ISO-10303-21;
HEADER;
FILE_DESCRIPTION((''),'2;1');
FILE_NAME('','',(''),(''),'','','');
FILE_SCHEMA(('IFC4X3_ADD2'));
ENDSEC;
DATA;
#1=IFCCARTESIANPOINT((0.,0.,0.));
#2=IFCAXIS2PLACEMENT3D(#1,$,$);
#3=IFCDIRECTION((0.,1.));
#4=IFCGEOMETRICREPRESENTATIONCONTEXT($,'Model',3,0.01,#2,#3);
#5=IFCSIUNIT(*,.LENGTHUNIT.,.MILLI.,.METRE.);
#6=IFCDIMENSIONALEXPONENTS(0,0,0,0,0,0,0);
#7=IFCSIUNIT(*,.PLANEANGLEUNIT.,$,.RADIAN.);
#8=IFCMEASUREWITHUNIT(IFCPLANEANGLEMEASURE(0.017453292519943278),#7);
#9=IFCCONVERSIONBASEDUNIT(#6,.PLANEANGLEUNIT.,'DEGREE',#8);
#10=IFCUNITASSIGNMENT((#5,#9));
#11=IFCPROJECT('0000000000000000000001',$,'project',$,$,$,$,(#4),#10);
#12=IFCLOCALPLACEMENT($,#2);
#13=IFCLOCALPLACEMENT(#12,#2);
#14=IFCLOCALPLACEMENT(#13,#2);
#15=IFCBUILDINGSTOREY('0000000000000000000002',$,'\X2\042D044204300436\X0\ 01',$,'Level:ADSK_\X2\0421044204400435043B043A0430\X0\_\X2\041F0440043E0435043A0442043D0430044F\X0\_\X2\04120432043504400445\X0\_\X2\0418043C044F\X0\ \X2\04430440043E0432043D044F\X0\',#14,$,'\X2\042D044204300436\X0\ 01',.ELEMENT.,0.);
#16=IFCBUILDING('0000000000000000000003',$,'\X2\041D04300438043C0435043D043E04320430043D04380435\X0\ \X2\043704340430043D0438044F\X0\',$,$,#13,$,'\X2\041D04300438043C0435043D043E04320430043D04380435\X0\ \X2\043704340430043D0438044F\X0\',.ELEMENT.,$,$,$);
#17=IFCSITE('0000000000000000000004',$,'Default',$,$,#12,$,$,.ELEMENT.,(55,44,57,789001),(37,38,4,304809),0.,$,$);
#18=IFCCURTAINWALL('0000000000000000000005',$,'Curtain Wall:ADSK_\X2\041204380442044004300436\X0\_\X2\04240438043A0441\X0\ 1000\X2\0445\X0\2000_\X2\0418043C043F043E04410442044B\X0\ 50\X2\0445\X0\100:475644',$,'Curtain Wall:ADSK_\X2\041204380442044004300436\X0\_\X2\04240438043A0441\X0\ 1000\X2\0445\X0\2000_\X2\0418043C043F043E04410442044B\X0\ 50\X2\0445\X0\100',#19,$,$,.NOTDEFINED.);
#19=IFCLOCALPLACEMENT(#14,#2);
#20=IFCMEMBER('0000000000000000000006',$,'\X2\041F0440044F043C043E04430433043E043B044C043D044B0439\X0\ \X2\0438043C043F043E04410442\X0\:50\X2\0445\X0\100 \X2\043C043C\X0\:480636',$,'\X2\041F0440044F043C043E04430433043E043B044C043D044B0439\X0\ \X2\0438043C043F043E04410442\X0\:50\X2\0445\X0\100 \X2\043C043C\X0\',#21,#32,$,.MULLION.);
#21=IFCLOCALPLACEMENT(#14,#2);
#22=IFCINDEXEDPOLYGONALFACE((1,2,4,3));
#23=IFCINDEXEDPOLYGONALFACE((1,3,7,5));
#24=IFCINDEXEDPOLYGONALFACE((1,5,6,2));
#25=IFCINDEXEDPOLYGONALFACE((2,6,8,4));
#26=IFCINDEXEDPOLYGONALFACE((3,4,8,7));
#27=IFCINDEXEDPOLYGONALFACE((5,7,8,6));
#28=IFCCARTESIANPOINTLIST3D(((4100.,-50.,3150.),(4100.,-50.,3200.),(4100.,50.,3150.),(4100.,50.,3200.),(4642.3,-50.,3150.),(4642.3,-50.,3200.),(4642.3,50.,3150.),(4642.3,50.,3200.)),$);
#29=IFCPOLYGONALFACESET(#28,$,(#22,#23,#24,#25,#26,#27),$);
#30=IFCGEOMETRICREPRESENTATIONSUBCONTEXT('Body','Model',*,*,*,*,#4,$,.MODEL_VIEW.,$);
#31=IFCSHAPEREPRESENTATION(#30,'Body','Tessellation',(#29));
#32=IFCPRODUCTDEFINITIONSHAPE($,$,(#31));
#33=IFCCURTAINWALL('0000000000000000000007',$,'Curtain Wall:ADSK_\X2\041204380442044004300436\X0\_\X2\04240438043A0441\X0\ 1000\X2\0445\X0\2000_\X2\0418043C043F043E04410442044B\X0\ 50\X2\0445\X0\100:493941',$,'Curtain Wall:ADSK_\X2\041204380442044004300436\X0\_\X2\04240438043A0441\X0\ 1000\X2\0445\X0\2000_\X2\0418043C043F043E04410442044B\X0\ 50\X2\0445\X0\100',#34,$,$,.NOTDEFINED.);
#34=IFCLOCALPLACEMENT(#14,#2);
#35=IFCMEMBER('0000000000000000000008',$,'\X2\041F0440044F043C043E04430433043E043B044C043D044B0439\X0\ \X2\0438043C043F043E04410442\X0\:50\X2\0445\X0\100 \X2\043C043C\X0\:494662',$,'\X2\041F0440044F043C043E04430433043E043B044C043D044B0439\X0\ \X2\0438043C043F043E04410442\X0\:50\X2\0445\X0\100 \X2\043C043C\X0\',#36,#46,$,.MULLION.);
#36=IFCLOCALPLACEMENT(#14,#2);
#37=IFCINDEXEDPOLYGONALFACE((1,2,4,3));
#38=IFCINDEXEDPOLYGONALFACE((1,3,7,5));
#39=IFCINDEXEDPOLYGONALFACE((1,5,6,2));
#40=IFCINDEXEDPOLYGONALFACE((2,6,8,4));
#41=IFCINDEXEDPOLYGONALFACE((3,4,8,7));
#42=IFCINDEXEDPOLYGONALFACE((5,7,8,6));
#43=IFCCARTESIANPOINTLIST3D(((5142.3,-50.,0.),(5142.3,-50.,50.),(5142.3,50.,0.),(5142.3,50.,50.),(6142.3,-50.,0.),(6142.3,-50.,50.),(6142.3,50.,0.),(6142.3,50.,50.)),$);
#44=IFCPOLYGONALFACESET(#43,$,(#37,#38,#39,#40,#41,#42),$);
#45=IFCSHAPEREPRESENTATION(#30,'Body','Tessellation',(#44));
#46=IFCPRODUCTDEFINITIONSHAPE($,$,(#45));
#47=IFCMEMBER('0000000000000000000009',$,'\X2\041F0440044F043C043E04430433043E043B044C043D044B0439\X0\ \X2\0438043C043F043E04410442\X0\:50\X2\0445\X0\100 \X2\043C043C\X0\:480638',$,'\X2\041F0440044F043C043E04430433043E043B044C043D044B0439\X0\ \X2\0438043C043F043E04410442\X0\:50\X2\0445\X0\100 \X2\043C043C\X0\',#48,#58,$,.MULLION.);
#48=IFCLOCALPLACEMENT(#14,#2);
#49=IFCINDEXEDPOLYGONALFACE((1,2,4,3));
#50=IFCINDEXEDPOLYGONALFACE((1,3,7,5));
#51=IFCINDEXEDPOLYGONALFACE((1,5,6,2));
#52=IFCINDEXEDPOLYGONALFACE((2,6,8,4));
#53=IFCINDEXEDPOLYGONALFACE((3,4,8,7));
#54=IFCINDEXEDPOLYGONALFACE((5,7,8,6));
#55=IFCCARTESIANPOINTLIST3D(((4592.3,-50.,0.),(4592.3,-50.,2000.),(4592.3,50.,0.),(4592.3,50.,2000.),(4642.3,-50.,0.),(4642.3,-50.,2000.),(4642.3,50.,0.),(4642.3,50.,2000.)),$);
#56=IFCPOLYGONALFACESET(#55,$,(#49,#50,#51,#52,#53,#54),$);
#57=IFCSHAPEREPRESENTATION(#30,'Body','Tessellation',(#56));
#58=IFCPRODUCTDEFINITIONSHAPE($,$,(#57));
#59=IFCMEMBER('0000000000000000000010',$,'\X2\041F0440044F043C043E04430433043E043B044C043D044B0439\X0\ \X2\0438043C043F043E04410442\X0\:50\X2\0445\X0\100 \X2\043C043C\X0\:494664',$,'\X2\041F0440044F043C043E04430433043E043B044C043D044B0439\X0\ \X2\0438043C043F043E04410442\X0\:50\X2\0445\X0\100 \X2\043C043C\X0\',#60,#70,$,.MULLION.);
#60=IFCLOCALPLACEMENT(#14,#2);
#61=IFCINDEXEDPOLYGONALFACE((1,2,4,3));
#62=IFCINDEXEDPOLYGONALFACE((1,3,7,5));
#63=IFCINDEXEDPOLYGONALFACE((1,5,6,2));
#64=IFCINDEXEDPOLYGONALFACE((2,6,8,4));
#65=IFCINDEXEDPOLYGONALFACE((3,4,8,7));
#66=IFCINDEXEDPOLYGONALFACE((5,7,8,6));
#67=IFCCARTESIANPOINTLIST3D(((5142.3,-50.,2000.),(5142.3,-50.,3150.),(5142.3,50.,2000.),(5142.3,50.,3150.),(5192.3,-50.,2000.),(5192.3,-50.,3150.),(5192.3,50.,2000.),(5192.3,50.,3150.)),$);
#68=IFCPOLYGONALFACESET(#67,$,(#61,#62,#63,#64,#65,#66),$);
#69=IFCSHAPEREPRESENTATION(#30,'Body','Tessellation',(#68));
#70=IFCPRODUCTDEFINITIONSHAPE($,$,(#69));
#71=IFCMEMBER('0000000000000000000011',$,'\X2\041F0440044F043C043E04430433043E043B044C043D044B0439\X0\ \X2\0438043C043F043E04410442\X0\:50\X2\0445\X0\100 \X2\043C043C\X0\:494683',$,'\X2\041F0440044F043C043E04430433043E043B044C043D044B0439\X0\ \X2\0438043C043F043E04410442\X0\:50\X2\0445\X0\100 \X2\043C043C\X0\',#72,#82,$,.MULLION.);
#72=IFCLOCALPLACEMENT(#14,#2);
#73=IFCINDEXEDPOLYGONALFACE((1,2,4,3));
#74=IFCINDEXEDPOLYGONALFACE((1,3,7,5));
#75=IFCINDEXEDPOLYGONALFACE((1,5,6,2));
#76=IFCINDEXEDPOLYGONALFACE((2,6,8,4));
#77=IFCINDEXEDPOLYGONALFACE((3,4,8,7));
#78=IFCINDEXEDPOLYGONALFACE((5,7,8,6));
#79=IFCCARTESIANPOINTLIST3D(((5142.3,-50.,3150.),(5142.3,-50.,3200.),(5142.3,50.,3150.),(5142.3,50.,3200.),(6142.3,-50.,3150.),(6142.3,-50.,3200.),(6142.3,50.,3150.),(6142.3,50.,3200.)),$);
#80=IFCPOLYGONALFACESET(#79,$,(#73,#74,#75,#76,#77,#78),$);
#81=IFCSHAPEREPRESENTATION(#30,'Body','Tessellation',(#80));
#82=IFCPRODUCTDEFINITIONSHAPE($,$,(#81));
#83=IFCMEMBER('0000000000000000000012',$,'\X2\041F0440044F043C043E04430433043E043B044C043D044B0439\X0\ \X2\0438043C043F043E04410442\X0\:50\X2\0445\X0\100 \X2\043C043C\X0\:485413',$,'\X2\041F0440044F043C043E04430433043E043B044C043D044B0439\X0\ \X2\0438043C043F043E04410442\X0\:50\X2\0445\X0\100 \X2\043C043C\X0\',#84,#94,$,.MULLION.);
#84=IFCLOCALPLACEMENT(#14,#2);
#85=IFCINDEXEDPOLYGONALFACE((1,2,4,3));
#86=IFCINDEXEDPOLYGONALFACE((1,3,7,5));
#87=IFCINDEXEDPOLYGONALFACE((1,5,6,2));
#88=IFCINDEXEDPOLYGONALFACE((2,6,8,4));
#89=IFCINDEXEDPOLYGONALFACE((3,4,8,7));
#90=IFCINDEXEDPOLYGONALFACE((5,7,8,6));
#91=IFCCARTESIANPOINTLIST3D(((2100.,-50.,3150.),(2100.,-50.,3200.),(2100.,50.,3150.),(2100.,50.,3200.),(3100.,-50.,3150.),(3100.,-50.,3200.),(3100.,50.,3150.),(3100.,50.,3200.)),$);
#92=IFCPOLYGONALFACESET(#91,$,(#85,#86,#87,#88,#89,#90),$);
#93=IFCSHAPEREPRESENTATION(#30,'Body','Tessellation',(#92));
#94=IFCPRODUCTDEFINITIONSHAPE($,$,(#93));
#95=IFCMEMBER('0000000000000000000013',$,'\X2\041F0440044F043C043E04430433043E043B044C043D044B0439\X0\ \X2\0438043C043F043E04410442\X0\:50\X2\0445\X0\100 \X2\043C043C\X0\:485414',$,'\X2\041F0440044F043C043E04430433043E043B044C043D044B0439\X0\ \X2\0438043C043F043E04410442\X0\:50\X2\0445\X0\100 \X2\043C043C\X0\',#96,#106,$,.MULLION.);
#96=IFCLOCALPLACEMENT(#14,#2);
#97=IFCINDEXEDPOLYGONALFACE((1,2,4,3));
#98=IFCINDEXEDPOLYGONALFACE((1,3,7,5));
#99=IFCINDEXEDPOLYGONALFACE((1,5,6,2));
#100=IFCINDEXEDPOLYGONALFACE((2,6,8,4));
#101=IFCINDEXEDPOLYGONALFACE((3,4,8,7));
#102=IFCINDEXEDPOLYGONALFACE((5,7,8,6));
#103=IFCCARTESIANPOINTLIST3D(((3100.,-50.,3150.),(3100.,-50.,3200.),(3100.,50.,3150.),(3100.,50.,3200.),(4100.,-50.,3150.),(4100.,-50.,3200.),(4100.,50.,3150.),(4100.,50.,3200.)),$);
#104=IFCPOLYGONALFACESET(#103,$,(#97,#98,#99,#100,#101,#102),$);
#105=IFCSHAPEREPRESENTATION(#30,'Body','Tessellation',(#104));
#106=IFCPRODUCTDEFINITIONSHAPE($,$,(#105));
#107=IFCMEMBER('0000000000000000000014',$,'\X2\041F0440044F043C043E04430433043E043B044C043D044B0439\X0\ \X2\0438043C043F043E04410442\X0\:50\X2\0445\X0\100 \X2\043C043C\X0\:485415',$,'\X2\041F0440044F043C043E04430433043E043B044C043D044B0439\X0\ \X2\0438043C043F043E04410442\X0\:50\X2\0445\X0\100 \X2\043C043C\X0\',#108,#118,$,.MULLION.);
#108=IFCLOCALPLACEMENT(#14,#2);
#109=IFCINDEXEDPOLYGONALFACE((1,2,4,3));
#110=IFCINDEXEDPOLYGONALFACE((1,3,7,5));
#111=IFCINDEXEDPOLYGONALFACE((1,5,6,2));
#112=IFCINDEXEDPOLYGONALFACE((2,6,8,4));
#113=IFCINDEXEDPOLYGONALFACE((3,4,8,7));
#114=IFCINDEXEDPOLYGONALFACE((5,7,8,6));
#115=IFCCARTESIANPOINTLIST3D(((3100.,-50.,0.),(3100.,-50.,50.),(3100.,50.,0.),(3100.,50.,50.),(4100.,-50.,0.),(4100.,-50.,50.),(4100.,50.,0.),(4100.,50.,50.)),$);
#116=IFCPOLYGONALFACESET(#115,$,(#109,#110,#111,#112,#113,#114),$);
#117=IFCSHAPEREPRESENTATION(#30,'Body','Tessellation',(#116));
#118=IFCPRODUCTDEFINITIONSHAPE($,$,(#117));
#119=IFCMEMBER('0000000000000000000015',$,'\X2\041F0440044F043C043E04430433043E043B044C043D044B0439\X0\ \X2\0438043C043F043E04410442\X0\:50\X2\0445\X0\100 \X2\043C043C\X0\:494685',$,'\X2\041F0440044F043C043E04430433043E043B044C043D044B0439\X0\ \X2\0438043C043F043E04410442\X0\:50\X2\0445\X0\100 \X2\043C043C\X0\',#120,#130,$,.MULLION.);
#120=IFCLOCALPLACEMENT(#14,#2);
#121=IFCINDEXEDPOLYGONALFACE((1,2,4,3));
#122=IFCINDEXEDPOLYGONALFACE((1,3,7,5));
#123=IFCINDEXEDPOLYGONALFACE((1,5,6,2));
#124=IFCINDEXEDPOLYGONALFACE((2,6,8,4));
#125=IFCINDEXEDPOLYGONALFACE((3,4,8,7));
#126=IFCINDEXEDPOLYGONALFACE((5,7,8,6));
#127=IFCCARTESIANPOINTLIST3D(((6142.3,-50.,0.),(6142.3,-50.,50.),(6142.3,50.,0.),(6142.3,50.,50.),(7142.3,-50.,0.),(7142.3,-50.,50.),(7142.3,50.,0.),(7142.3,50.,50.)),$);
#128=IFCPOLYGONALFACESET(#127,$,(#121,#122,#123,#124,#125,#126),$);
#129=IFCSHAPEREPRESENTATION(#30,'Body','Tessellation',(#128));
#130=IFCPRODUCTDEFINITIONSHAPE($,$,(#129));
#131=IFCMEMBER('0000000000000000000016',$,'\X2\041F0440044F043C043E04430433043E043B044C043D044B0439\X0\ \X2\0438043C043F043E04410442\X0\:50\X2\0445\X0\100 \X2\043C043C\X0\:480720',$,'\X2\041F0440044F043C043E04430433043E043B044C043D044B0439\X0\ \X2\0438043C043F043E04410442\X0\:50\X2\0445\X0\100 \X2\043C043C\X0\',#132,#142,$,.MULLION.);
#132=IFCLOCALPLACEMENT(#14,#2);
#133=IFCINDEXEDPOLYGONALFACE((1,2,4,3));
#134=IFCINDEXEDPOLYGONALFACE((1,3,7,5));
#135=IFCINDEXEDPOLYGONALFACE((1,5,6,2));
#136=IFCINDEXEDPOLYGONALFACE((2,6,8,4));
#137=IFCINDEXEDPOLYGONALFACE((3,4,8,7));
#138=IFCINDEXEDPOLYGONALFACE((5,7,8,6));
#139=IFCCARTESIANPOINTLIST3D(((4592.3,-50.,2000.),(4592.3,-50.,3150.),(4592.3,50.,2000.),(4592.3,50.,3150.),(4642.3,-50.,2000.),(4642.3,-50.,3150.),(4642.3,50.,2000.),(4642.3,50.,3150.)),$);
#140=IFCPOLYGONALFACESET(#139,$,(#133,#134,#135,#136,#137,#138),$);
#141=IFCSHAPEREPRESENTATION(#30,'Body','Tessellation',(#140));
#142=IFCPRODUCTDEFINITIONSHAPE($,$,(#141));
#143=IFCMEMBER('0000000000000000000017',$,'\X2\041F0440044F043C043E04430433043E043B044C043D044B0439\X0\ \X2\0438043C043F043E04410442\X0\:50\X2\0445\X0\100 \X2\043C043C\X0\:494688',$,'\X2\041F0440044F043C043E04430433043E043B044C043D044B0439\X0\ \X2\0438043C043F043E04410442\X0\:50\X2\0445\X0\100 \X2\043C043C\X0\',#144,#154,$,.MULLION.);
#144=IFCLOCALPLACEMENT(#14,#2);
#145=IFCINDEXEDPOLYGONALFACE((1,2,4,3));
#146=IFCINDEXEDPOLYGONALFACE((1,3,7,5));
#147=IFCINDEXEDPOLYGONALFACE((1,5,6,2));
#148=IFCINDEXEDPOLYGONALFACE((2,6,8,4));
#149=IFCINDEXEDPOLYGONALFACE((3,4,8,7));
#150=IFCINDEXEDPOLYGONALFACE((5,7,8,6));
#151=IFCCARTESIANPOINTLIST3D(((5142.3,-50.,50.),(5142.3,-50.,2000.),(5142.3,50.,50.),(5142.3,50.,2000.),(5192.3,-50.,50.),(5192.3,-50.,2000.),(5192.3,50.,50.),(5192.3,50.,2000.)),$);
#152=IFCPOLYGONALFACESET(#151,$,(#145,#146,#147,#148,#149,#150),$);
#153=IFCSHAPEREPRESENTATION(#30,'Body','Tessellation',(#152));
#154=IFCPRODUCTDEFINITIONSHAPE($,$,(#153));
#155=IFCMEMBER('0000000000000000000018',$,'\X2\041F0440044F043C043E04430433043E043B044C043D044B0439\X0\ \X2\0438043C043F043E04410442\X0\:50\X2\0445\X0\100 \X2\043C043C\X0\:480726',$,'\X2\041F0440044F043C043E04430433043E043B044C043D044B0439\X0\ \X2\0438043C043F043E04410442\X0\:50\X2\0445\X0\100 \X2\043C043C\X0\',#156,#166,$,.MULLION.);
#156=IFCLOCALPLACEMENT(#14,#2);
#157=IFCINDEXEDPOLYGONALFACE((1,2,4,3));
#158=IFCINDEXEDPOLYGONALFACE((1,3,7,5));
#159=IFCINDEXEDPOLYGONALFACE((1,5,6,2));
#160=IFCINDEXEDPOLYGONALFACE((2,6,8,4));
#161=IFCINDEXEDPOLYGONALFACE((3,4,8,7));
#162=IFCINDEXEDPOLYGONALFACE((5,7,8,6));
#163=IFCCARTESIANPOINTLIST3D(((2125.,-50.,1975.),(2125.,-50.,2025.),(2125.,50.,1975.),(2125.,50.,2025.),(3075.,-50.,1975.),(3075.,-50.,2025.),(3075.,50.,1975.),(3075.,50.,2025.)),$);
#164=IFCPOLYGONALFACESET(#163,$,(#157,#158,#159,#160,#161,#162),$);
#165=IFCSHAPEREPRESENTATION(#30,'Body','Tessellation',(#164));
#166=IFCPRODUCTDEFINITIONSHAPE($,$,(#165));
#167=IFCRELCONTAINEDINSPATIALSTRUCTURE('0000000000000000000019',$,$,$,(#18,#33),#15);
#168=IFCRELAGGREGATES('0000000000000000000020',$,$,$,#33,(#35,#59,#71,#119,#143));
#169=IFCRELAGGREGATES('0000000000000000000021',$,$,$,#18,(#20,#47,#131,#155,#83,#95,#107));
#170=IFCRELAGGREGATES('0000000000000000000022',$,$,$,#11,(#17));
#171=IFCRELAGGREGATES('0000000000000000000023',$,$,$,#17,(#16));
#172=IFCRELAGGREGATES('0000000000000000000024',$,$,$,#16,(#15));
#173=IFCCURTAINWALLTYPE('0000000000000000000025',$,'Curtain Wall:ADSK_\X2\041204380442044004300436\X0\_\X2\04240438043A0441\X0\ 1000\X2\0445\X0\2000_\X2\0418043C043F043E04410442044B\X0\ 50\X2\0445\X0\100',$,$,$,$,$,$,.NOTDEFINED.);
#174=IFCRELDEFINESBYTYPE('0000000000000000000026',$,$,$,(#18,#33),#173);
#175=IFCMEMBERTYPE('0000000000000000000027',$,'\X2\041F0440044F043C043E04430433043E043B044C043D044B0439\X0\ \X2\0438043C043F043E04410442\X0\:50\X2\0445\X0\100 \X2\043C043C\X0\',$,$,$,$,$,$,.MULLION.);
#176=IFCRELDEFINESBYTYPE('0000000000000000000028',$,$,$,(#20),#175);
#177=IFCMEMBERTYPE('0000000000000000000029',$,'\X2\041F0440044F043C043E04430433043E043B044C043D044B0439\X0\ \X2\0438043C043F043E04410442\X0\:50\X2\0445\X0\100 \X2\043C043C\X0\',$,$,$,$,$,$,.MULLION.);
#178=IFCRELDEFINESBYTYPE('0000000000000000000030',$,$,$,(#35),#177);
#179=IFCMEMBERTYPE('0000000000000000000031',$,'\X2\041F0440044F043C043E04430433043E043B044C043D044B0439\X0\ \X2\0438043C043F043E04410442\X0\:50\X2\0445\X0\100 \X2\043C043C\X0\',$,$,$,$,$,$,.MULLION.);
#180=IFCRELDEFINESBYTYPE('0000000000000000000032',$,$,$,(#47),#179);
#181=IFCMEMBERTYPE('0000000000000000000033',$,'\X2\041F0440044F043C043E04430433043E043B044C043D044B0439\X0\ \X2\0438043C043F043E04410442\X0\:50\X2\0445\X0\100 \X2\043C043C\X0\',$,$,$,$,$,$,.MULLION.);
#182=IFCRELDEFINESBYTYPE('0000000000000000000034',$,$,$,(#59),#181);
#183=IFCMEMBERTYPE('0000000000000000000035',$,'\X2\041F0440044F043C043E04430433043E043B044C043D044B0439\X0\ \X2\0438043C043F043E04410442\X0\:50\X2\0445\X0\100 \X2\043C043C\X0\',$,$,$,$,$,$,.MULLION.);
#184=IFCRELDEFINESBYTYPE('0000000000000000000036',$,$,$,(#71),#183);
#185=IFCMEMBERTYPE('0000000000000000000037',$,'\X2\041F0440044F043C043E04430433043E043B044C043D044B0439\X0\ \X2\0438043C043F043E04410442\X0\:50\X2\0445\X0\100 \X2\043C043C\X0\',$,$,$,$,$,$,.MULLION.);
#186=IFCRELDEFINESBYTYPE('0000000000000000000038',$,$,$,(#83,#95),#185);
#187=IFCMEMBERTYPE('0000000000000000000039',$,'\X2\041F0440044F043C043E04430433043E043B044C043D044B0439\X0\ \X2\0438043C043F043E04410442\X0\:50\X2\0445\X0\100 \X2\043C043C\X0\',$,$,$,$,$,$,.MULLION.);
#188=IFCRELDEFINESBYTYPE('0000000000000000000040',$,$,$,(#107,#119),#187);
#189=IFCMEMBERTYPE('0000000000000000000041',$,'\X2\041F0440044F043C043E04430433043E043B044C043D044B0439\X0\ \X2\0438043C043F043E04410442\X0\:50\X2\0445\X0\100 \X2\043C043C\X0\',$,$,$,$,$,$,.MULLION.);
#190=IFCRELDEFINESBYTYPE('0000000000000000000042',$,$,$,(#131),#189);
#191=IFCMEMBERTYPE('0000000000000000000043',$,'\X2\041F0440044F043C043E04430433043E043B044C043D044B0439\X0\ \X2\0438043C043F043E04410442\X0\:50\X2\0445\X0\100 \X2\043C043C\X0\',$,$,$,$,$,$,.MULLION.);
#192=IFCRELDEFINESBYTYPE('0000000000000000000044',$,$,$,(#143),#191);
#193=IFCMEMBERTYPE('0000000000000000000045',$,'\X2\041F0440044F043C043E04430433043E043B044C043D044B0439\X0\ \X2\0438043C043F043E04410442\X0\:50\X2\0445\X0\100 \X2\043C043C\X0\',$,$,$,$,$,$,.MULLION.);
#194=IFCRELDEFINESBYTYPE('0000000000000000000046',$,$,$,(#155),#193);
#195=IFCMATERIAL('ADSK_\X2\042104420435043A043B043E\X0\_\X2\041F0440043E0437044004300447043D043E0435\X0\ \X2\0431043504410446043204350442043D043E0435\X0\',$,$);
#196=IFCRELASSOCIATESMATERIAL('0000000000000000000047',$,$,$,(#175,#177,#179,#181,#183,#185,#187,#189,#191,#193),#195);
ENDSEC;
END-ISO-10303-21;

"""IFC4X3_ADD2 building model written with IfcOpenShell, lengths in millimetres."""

from ifc_helpers import new_model, entity, si_unit, converted_unit, direction, frame, frame_2d, origin, place, context, subcontext, project, spatial, rectangle, extrude, source, transform, mapped, material, material_profile, profile_set, type_object, type_shapes, element, aggregate, save


model = new_model("IFC4X3_ADD2")

# Units and contexts
model_context = context("Model", 3, precision=0.01, world=origin(), true_north=direction((0.0, 1.0)))
body_context = subcontext(model_context, "Body", "Model", "MODEL_VIEW")
ifc_project = project(units=[si_unit("LENGTHUNIT", "METRE", prefix="MILLI"), converted_unit("PLANEANGLEUNIT", "DEGREE", entity("IfcPlaneAngleMeasure", 0.017453292519943278), si_unit("PLANEANGLEUNIT", "RADIAN"), dimensions=[0, 0, 0, 0, 0, 0, 0])], contexts=[model_context])

# Site, building, storey
site_placement = place(None, origin())
site = spatial("IfcSite", under=ifc_project, at=site_placement, Name="Default", CompositionType="ELEMENT", RefLatitude=(55, 44, 57, 789001), RefLongitude=(37, 38, 4, 304809), RefElevation=0.0)
building_placement = place(site_placement, origin())
building = spatial("IfcBuilding", under=site, at=building_placement, Name="Наименование здания", LongName="Наименование здания", CompositionType="ELEMENT")
storey_placement = place(building_placement, origin())
storey = spatial("IfcBuildingStorey", under=building, at=storey_placement, Name="Этаж 01", ObjectType="Level:ADSK_Стрелка_Проектная_Вверх_Имя уровня", LongName="Этаж 01", CompositionType="ELEMENT", Elevation=0.0)

# Curtain walls, members
curtain_wall_type = type_object("IfcCurtainWallType", Name="Curtain Wall:ADSK_Витраж_Фикс 1000х2000_Импосты 50х100", PredefinedType="NOTDEFINED")
curtain_wall_1_placement = place(storey_placement, origin())
curtain_wall_1 = element("IfcCurtainWall", 1, at=curtain_wall_1_placement, inside=storey, type_object=curtain_wall_type, Name="Curtain Wall:ADSK_Витраж_Фикс 1000х2000_Импосты 50х100:475644", ObjectType="Curtain Wall:ADSK_Витраж_Фикс 1000х2000_Импосты 50х100", PredefinedType="NOTDEFINED")
ifc_material_1 = material(Name="ADSK_Стекло_Прозрачное бесцветное")
ifc_material_profile = material_profile(ifc_material_1, rectangle(XDim=50.0, YDim=100.0, at=frame_2d((0.0, 0.0), x_axis=(1.0, 0.0))), Name="50х100 мм")
ifc_profile_set = profile_set([ifc_material_profile], Name="50х100 мм")
member_type_1 = type_object("IfcMemberType", Name="Прямоугольный импост:50х100 мм", PredefinedType="MULLION", material=ifc_profile_set)
shared_shape_1 = source(origin(), body_context, "Body", "SweptSolid", [
    extrude(rectangle(XDim=50.0, YDim=100.0, at=frame_2d((0.0, 0.0), x_axis=(1.0, 0.0))), frame((-25.0, 0.0, -542.3), z_axis=(0.0, 0.0, 1.0), x_axis=(-1.0, 0.0, 0.0)), (0.0, 0.0, 1.0), 542.3),
])
type_shapes(member_type_1, [shared_shape_1])
member_1_placement = place(curtain_wall_1_placement, frame((4642.3, 0.0, 3200.0), z_axis=(1.0, 0.0, 0.0), x_axis=(0.0, 0.0, 1.0)))
member_1 = element("IfcMember", 2, at=member_1_placement, type_object=member_type_1, Name="Прямоугольный импост:50х100 мм:480636", ObjectType="Прямоугольный импост:50х100 мм", PredefinedType="MULLION", context=body_context, shape_type="MappedRepresentation", body=[
    mapped(shared_shape_1, transform((0.0, 0.0, 0.0), scale=1.0)),
])
curtain_wall_2_placement = place(storey_placement, origin())
curtain_wall_2 = element("IfcCurtainWall", 3, at=curtain_wall_2_placement, inside=storey, type_object=curtain_wall_type, Name="Curtain Wall:ADSK_Витраж_Фикс 1000х2000_Импосты 50х100:493941", ObjectType="Curtain Wall:ADSK_Витраж_Фикс 1000х2000_Импосты 50х100", PredefinedType="NOTDEFINED")
member_type_2 = type_object("IfcMemberType", Name="Прямоугольный импост:50х100 мм", PredefinedType="MULLION", material=ifc_profile_set)
shared_shape_2 = source(origin(), body_context, "Body", "SweptSolid", [
    extrude(rectangle(XDim=50.0, YDim=100.0, at=frame_2d((0.0, 0.0), x_axis=(1.0, 0.0))), frame((-25.0, 0.0, -1000.0), z_axis=(0.0, 0.0, 1.0), x_axis=(-1.0, 0.0, 0.0)), (0.0, 0.0, 1.0), 1000.0),
])
type_shapes(member_type_2, [shared_shape_2])
member_2_placement = place(curtain_wall_2_placement, frame((5142.3, 0.0, 0.0), z_axis=(-1.0, 0.0, 0.0), x_axis=(0.0, 0.0, -1.0)))
member_2 = element("IfcMember", 4, at=member_2_placement, type_object=member_type_2, Name="Прямоугольный импост:50х100 мм:494662", ObjectType="Прямоугольный импост:50х100 мм", PredefinedType="MULLION", context=body_context, shape_type="MappedRepresentation", body=[
    mapped(shared_shape_2, transform((0.0, 0.0, 0.0), scale=1.0)),
])

# Members
member_type_3 = type_object("IfcMemberType", Name="Прямоугольный импост:50х100 мм", PredefinedType="MULLION", material=ifc_profile_set)
shared_shape_3 = source(origin(), body_context, "Body", "SweptSolid", [
    extrude(rectangle(XDim=50.0, YDim=100.0, at=frame_2d((0.0, 0.0), x_axis=(1.0, 0.0))), frame((-25.0, 0.0, -2000.0), z_axis=(0.0, 0.0, 1.0), x_axis=(-1.0, 0.0, 0.0)), (0.0, 0.0, 1.0), 2000.0),
])
type_shapes(member_type_3, [shared_shape_3])
member_3_placement = place(curtain_wall_1_placement, frame((4642.3, 0.0, 0.0), z_axis=(0.0, 0.0, -1.0), x_axis=(1.0, 0.0, 0.0)))
member_3 = element("IfcMember", 5, at=member_3_placement, type_object=member_type_3, Name="Прямоугольный импост:50х100 мм:480638", ObjectType="Прямоугольный импост:50х100 мм", PredefinedType="MULLION", context=body_context, shape_type="MappedRepresentation", body=[
    mapped(shared_shape_3, transform((0.0, 0.0, 0.0), scale=1.0)),
])
member_type_4 = type_object("IfcMemberType", Name="Прямоугольный импост:50х100 мм", PredefinedType="MULLION", material=ifc_profile_set)
shared_shape_4 = source(origin(), body_context, "Body", "SweptSolid", [
    extrude(rectangle(XDim=50.0, YDim=100.0, at=frame_2d((0.0, 0.0), x_axis=(1.0, 0.0))), frame((-25.0, 0.0, -1150.0), z_axis=(0.0, 0.0, 1.0), x_axis=(-1.0, 0.0, 0.0)), (0.0, 0.0, 1.0), 1150.0),
])
type_shapes(member_type_4, [shared_shape_4])
member_4_placement = place(curtain_wall_2_placement, frame((5142.3, 0.0, 3150.0), z_axis=(0.0, 0.0, 1.0), x_axis=(-1.0, 0.0, 0.0)))
member_4 = element("IfcMember", 6, at=member_4_placement, type_object=member_type_4, Name="Прямоугольный импост:50х100 мм:494664", ObjectType="Прямоугольный импост:50х100 мм", PredefinedType="MULLION", context=body_context, shape_type="MappedRepresentation", body=[
    mapped(shared_shape_4, transform((0.0, 0.0, 0.0), scale=1.0)),
])
member_type_5 = type_object("IfcMemberType", Name="Прямоугольный импост:50х100 мм", PredefinedType="MULLION", material=ifc_profile_set)
shared_shape_5 = source(origin(), body_context, "Body", "SweptSolid", [
    extrude(rectangle(XDim=50.0, YDim=100.0, at=frame_2d((0.0, 0.0), x_axis=(1.0, 0.0))), frame((-25.0, 0.0, -1000.0), z_axis=(0.0, 0.0, 1.0), x_axis=(-1.0, 0.0, 0.0)), (0.0, 0.0, 1.0), 1000.0),
])
type_shapes(member_type_5, [shared_shape_5])
member_5_placement = place(curtain_wall_2_placement, frame((6142.3, 0.0, 3200.0), z_axis=(1.0, 0.0, 0.0), x_axis=(0.0, 0.0, 1.0)))
member_5 = element("IfcMember", 7, at=member_5_placement, type_object=member_type_5, Name="Прямоугольный импост:50х100 мм:494683", ObjectType="Прямоугольный импост:50х100 мм", PredefinedType="MULLION", context=body_context, shape_type="MappedRepresentation", body=[
    mapped(shared_shape_5, transform((0.0, 0.0, 0.0), scale=1.0)),
])
member_type_6 = type_object("IfcMemberType", Name="Прямоугольный импост:50х100 мм", PredefinedType="MULLION", material=ifc_profile_set)
shared_shape_6 = source(origin(), body_context, "Body", "SweptSolid", [
    extrude(rectangle(XDim=50.0, YDim=100.0, at=frame_2d((0.0, 0.0), x_axis=(1.0, 0.0))), frame((-25.0, 0.0, -1000.0), z_axis=(0.0, 0.0, 1.0), x_axis=(-1.0, 0.0, 0.0)), (0.0, 0.0, 1.0), 1000.0),
])
type_shapes(member_type_6, [shared_shape_6])
member_6_placement = place(curtain_wall_1_placement, frame((3100.0, 0.0, 3200.0), z_axis=(1.0, 0.0, 0.0), x_axis=(0.0, 0.0, 1.0)))
member_6 = element("IfcMember", 8, at=member_6_placement, type_object=member_type_6, Name="Прямоугольный импост:50х100 мм:485413", ObjectType="Прямоугольный импост:50х100 мм", PredefinedType="MULLION", context=body_context, shape_type="MappedRepresentation", body=[
    mapped(shared_shape_6, transform((0.0, 0.0, 0.0), scale=1.0)),
])
member_7_placement = place(curtain_wall_1_placement, frame((4100.0, 0.0, 3200.0), z_axis=(1.0, 0.0, 0.0), x_axis=(0.0, 0.0, 1.0)))
member_7 = element("IfcMember", 9, at=member_7_placement, type_object=member_type_6, Name="Прямоугольный импост:50х100 мм:485414", ObjectType="Прямоугольный импост:50х100 мм", PredefinedType="MULLION", context=body_context, shape_type="MappedRepresentation", body=[
    mapped(shared_shape_6, transform((0.0, 0.0, 0.0), scale=1.0)),
])
member_type_7 = type_object("IfcMemberType", Name="Прямоугольный импост:50х100 мм", PredefinedType="MULLION", material=ifc_profile_set)
shared_shape_7 = source(origin(), body_context, "Body", "SweptSolid", [
    extrude(rectangle(XDim=50.0, YDim=100.0, at=frame_2d((0.0, 0.0), x_axis=(1.0, 0.0))), frame((-25.0, 0.0, -1000.0), z_axis=(0.0, 0.0, 1.0), x_axis=(-1.0, 0.0, 0.0)), (0.0, 0.0, 1.0), 1000.0),
])
type_shapes(member_type_7, [shared_shape_7])
member_8_placement = place(curtain_wall_1_placement, frame((3100.0, 0.0, 0.0), z_axis=(-1.0, 0.0, 0.0), x_axis=(0.0, 0.0, -1.0)))
member_8 = element("IfcMember", 10, at=member_8_placement, type_object=member_type_7, Name="Прямоугольный импост:50х100 мм:485415", ObjectType="Прямоугольный импост:50х100 мм", PredefinedType="MULLION", context=body_context, shape_type="MappedRepresentation", body=[
    mapped(shared_shape_7, transform((0.0, 0.0, 0.0), scale=1.0)),
])
member_9_placement = place(curtain_wall_2_placement, frame((6142.3, 0.0, 0.0), z_axis=(-1.0, 0.0, 0.0), x_axis=(0.0, 0.0, -1.0)))
member_9 = element("IfcMember", 11, at=member_9_placement, type_object=member_type_7, Name="Прямоугольный импост:50х100 мм:494685", ObjectType="Прямоугольный импост:50х100 мм", PredefinedType="MULLION", context=body_context, shape_type="MappedRepresentation", body=[
    mapped(shared_shape_7, transform((0.0, 0.0, 0.0), scale=1.0)),
])
member_type_8 = type_object("IfcMemberType", Name="Прямоугольный импост:50х100 мм", PredefinedType="MULLION", material=ifc_profile_set)
shared_shape_8 = source(origin(), body_context, "Body", "SweptSolid", [
    extrude(rectangle(XDim=50.0, YDim=100.0, at=frame_2d((0.0, 0.0), x_axis=(1.0, 0.0))), frame((-25.0, 0.0, -1150.0), z_axis=(0.0, 0.0, 1.0), x_axis=(-1.0, 0.0, 0.0)), (0.0, 0.0, 1.0), 1150.0),
])
type_shapes(member_type_8, [shared_shape_8])
member_10_placement = place(curtain_wall_1_placement, frame((4642.3, 0.0, 2000.0), z_axis=(0.0, 0.0, -1.0), x_axis=(1.0, 0.0, 0.0)))
member_10 = element("IfcMember", 12, at=member_10_placement, type_object=member_type_8, Name="Прямоугольный импост:50х100 мм:480720", ObjectType="Прямоугольный импост:50х100 мм", PredefinedType="MULLION", context=body_context, shape_type="MappedRepresentation", body=[
    mapped(shared_shape_8, transform((0.0, 0.0, 0.0), scale=1.0)),
])
member_type_9 = type_object("IfcMemberType", Name="Прямоугольный импост:50х100 мм", PredefinedType="MULLION", material=ifc_profile_set)
shared_shape_9 = source(origin(), body_context, "Body", "SweptSolid", [
    extrude(rectangle(XDim=50.0, YDim=100.0, at=frame_2d((0.0, 0.0), x_axis=(1.0, 0.0))), frame((-25.0, 0.0, -1950.0), z_axis=(0.0, 0.0, 1.0), x_axis=(-1.0, 0.0, 0.0)), (0.0, 0.0, 1.0), 1950.0),
])
type_shapes(member_type_9, [shared_shape_9])
member_11_placement = place(curtain_wall_2_placement, frame((5142.3, 0.0, 2000.0), z_axis=(0.0, 0.0, 1.0), x_axis=(-1.0, 0.0, 0.0)))
member_11 = element("IfcMember", 13, at=member_11_placement, type_object=member_type_9, Name="Прямоугольный импост:50х100 мм:494688", ObjectType="Прямоугольный импост:50х100 мм", PredefinedType="MULLION", context=body_context, shape_type="MappedRepresentation", body=[
    mapped(shared_shape_9, transform((0.0, 0.0, 0.0), scale=1.0)),
])
member_type_10 = type_object("IfcMemberType", Name="Прямоугольный импост:50х100 мм", PredefinedType="MULLION", material=ifc_profile_set)
shared_shape_10 = source(origin(), body_context, "Body", "SweptSolid", [
    extrude(rectangle(XDim=50.0, YDim=100.0, at=frame_2d((0.0, 0.0), x_axis=(1.0, 0.0))), frame((0.0, 0.0, -950.0), z_axis=(0.0, 0.0, 1.0), x_axis=(-1.0, 0.0, 0.0)), (0.0, 0.0, 1.0), 950.0),
])
type_shapes(member_type_10, [shared_shape_10])
member_12_placement = place(curtain_wall_1_placement, frame((3075.0, 0.0, 2000.0), z_axis=(1.0, 0.0, 0.0), x_axis=(0.0, 0.0, 1.0)))
member_12 = element("IfcMember", 14, at=member_12_placement, type_object=member_type_10, Name="Прямоугольный импост:50х100 мм:480726", ObjectType="Прямоугольный импост:50х100 мм", PredefinedType="MULLION", context=body_context, shape_type="MappedRepresentation", body=[
    mapped(shared_shape_10, transform((0.0, 0.0, 0.0), scale=1.0)),
])

aggregate(curtain_wall_2, [member_2, member_4, member_5, member_9, member_11])
aggregate(curtain_wall_1, [member_1, member_3, member_10, member_12, member_6, member_7, member_8])

save(model, "model.ifc")
